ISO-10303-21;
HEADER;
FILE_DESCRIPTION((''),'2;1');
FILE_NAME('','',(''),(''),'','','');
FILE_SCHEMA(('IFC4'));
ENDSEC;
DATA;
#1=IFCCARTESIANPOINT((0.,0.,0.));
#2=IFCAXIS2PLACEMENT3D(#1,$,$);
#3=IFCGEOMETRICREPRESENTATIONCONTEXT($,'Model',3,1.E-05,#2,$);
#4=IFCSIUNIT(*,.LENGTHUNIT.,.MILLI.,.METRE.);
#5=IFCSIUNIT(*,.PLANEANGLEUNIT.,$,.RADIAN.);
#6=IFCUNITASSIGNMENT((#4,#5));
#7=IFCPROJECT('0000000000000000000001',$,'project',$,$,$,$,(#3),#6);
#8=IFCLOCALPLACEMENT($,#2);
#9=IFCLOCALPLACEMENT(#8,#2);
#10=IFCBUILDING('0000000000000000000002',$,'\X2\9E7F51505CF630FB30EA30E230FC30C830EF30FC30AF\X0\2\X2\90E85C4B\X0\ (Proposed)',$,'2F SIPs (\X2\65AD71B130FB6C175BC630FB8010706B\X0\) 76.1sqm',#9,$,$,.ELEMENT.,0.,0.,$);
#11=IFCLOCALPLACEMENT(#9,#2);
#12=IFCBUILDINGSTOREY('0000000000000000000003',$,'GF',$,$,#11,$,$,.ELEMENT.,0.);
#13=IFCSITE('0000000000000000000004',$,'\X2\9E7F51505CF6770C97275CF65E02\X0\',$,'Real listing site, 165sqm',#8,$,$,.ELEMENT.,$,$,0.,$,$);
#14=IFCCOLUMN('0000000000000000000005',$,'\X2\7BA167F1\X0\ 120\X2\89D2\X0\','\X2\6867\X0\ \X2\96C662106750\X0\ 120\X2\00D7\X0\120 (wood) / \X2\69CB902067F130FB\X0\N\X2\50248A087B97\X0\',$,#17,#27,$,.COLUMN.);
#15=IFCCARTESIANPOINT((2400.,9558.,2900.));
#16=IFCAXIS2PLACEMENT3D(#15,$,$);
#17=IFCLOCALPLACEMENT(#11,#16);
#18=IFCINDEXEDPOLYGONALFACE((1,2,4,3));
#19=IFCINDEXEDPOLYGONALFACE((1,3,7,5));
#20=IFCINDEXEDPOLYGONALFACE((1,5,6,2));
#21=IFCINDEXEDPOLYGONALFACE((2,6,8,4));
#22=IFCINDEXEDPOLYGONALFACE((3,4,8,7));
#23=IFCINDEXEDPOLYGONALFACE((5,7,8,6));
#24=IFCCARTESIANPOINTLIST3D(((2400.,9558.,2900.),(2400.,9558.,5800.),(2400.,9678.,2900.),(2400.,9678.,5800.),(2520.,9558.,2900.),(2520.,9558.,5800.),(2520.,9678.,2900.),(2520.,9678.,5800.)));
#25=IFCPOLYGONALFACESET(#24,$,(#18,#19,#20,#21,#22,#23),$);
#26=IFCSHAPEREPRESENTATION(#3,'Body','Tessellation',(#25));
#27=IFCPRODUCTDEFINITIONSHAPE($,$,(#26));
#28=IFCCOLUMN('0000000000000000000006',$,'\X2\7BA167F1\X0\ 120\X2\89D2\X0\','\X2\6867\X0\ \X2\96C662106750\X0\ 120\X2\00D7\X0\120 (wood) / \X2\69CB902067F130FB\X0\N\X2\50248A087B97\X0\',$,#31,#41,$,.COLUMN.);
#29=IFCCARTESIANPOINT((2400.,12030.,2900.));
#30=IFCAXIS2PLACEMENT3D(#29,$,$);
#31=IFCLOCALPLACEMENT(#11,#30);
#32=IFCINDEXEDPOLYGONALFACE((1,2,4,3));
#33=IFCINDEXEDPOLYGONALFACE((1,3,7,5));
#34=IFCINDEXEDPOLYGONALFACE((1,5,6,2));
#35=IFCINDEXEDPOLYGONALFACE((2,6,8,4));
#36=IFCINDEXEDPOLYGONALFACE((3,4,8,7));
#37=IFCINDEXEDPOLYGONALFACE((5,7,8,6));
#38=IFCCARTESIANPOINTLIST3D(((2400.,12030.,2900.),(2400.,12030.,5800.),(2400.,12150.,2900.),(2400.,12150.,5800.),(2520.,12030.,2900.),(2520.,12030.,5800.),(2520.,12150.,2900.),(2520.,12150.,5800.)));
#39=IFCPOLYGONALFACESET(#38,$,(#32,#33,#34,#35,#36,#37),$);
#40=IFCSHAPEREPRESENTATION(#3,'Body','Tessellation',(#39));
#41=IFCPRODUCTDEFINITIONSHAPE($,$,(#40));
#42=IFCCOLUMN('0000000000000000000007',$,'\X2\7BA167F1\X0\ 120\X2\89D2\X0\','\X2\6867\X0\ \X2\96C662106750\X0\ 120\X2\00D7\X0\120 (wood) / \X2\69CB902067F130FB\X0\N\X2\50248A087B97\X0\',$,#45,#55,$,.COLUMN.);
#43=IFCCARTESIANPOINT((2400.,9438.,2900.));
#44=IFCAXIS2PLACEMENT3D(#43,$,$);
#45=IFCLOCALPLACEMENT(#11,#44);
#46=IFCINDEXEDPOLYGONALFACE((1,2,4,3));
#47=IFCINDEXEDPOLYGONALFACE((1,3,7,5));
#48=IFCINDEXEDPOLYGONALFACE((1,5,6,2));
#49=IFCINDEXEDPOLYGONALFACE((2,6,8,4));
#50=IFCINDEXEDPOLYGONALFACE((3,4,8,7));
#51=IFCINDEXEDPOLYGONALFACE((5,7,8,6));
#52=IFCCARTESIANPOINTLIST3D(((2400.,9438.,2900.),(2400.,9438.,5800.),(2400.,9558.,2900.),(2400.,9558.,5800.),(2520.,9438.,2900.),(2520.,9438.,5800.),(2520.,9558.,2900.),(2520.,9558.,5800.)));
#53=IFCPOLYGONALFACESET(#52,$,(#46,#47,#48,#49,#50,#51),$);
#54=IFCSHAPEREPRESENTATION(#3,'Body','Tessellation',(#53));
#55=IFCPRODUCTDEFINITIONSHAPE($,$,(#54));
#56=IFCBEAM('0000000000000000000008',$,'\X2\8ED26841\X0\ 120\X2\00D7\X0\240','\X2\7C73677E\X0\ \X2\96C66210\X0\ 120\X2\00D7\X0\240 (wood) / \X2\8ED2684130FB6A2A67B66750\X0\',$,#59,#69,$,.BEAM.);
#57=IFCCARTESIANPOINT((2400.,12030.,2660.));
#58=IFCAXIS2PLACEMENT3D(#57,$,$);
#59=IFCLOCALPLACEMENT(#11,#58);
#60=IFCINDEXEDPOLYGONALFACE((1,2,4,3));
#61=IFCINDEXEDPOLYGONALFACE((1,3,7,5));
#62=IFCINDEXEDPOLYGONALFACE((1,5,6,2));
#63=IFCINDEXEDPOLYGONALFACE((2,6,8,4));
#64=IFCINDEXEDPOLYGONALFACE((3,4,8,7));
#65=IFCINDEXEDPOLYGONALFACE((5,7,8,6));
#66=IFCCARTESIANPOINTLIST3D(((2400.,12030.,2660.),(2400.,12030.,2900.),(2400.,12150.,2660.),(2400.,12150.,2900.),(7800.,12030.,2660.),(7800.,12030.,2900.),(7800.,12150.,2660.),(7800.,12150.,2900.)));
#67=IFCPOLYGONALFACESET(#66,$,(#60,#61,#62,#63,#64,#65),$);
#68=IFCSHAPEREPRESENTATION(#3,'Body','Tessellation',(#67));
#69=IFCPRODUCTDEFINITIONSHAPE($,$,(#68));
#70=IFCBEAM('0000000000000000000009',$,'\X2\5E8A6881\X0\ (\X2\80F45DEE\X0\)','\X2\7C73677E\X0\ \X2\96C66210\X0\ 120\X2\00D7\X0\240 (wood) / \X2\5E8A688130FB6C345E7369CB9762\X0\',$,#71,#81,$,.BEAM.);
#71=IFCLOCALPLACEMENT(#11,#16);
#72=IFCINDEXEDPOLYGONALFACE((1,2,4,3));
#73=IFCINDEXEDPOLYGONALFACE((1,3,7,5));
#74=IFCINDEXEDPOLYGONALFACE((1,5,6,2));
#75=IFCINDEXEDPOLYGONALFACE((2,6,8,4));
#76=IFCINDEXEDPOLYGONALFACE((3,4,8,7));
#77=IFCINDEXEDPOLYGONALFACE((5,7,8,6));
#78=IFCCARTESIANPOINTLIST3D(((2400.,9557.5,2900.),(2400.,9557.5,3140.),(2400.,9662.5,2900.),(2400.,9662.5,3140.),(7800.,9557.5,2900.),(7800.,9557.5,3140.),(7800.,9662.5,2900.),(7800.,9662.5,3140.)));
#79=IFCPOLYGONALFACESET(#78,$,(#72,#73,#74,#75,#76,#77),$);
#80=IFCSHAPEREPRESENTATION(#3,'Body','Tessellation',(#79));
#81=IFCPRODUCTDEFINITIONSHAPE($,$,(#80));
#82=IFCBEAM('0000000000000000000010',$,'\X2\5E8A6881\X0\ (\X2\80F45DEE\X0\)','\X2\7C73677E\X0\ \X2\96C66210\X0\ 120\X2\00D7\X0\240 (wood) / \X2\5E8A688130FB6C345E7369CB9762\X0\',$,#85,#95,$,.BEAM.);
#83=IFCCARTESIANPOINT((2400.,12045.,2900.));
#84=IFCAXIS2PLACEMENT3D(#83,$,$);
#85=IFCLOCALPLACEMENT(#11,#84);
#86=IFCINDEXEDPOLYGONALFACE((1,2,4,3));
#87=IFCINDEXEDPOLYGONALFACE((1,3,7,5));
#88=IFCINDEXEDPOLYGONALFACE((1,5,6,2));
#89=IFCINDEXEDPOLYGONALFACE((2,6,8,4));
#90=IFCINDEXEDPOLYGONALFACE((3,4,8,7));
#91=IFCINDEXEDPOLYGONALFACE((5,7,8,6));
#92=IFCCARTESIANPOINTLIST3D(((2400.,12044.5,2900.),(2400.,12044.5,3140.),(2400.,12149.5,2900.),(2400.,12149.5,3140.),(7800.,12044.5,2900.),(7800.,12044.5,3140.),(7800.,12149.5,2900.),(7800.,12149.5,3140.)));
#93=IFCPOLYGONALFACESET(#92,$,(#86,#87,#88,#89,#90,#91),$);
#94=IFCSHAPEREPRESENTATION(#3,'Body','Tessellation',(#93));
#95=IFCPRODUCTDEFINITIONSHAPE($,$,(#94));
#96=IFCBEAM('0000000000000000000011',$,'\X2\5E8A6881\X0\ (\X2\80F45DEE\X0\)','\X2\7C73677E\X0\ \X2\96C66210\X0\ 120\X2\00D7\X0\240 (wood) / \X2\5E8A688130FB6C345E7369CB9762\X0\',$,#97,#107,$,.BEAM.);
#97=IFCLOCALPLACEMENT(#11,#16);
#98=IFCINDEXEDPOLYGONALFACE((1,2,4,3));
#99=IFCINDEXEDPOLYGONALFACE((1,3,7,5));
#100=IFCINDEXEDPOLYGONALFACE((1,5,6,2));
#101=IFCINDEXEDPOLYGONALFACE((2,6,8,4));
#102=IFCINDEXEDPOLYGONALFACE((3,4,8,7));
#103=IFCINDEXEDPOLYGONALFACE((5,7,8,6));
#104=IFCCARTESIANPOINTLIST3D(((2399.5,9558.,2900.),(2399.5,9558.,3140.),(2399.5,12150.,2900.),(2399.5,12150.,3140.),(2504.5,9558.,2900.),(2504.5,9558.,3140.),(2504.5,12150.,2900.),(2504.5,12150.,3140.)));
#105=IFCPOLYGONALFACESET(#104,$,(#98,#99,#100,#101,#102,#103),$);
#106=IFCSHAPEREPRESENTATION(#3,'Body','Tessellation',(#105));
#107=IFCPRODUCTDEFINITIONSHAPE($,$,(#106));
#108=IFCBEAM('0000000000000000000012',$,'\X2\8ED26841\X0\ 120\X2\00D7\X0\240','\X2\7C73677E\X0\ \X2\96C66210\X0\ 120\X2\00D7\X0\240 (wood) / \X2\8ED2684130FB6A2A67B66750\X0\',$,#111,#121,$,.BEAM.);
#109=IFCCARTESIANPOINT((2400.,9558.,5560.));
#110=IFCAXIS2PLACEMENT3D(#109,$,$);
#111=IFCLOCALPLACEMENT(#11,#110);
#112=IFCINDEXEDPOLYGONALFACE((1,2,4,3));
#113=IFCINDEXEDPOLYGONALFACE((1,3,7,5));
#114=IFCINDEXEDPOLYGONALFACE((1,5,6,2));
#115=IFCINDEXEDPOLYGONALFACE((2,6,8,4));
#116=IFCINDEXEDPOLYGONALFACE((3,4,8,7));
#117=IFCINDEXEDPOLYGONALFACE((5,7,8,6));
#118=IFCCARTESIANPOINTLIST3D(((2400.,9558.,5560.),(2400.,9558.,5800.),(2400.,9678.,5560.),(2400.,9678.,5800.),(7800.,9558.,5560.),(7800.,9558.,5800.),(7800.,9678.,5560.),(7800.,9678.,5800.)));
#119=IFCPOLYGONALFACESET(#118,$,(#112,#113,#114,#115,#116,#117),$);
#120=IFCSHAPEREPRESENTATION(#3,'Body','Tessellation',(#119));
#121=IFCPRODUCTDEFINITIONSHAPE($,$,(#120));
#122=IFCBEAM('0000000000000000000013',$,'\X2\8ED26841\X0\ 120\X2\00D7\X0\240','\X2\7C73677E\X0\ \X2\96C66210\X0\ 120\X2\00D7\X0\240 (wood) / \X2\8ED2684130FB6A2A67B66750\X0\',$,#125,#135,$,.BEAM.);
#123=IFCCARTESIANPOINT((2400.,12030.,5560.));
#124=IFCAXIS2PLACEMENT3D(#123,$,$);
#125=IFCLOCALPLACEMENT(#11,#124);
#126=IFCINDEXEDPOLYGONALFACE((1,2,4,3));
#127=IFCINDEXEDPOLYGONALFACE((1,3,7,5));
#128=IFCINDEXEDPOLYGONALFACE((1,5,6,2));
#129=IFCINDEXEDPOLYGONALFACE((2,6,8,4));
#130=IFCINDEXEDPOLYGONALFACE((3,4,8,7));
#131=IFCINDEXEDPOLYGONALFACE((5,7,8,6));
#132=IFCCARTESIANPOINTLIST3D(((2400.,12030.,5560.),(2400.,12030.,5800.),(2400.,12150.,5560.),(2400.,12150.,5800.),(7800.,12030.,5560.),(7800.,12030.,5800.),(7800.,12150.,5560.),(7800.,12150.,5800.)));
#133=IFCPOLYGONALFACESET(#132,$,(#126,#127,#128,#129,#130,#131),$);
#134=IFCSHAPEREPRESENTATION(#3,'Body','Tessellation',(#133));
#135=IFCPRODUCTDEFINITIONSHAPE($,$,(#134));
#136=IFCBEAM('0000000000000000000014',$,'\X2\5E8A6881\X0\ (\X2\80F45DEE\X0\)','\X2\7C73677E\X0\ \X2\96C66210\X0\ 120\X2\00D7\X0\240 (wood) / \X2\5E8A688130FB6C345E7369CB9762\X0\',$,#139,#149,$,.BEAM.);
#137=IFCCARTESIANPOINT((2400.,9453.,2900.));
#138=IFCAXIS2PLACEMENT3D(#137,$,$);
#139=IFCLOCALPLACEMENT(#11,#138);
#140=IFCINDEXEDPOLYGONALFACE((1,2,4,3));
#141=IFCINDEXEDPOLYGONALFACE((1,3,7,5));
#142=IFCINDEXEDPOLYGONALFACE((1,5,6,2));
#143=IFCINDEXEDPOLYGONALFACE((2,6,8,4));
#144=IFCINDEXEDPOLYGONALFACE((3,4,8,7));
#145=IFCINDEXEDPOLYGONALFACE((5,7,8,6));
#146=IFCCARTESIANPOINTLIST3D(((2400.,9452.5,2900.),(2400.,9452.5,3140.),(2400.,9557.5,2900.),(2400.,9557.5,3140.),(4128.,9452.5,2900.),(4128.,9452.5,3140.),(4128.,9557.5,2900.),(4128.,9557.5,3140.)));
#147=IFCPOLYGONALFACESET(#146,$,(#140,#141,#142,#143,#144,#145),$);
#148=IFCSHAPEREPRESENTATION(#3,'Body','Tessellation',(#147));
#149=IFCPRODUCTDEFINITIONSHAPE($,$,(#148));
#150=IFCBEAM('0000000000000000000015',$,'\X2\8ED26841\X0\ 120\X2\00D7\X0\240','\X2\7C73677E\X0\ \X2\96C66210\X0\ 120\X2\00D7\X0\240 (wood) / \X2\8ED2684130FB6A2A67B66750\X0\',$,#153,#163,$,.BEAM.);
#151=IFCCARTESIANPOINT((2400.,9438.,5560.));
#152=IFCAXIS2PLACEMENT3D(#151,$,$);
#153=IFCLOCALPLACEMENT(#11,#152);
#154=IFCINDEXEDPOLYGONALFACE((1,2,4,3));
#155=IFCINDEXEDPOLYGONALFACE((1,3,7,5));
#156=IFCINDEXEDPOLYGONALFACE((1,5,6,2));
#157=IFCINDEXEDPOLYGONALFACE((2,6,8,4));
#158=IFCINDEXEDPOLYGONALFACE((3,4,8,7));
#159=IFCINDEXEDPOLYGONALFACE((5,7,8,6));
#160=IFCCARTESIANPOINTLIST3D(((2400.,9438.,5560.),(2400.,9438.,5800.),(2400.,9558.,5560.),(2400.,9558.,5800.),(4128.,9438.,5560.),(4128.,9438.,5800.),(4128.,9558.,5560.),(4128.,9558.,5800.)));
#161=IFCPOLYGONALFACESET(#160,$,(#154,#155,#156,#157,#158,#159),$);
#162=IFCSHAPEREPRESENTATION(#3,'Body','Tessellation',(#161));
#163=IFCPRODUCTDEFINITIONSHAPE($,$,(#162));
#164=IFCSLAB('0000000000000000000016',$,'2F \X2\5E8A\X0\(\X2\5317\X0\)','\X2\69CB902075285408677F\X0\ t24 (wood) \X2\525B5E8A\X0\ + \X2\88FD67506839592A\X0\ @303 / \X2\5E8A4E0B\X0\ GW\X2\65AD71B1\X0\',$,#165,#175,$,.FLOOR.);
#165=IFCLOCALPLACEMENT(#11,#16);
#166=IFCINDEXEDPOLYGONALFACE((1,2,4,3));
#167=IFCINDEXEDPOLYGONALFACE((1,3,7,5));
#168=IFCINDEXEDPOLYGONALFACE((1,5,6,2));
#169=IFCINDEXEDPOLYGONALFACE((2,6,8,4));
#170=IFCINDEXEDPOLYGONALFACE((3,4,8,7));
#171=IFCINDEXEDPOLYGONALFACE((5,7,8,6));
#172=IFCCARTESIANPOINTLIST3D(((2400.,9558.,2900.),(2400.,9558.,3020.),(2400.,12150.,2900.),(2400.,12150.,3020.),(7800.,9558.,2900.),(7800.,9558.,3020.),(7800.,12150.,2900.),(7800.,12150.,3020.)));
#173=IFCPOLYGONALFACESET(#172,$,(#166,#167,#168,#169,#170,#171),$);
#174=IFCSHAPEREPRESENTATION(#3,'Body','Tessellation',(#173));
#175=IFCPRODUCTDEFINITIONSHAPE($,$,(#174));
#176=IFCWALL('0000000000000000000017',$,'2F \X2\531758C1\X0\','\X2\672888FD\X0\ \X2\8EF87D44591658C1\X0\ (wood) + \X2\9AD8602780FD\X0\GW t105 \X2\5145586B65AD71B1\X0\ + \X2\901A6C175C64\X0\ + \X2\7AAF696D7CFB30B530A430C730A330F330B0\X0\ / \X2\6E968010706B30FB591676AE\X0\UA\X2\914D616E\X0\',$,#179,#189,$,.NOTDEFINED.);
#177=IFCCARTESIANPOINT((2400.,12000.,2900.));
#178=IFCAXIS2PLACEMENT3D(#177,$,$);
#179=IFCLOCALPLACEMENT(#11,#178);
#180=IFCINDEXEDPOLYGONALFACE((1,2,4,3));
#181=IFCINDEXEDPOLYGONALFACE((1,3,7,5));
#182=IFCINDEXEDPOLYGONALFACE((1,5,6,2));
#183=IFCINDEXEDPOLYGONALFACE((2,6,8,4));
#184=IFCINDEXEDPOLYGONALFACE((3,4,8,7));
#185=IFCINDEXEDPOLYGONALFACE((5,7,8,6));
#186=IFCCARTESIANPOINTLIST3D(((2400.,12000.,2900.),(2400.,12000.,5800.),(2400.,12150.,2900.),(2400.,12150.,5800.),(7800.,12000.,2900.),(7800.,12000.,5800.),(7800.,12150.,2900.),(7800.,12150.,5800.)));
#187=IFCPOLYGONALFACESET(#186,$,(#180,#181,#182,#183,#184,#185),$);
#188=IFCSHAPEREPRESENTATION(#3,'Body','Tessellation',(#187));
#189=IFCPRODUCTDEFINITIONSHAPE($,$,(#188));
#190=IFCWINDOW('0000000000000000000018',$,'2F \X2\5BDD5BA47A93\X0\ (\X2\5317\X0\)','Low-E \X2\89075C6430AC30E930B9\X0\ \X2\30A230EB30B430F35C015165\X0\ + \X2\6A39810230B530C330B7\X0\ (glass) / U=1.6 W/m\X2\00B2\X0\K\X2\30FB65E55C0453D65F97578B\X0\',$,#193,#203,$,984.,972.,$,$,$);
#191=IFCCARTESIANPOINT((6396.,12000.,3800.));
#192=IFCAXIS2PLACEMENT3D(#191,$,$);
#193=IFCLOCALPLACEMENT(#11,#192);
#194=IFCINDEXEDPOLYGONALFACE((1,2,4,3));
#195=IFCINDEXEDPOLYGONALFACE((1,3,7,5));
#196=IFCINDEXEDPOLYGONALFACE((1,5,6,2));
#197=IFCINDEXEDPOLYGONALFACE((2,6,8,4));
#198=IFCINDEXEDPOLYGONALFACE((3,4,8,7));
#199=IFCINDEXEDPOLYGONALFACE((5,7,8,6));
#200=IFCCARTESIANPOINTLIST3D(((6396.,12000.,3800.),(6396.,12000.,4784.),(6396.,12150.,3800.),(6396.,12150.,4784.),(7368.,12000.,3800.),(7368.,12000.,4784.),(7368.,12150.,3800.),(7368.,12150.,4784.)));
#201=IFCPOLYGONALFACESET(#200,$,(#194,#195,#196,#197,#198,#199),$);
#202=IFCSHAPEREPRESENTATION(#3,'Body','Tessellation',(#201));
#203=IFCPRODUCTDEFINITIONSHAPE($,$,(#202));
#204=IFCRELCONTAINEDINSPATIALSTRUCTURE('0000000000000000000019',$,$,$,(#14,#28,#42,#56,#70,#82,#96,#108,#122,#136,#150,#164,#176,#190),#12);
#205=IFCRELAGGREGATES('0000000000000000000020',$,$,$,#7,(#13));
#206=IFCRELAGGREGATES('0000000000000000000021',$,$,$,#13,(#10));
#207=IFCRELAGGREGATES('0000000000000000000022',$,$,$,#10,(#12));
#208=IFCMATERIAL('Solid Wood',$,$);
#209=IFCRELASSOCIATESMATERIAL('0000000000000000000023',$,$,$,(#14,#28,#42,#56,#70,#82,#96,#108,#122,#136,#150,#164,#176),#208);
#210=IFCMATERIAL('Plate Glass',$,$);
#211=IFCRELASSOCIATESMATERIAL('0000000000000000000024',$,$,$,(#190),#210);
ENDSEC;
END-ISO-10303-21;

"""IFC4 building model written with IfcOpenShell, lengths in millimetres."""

from ifc_helpers import new_model, si_unit, frame, frame_2d, origin, place, context, project, spatial, rectangle, extrude, material, element, fill, save


model = new_model("IFC4")

# Units and contexts
model_context = context("Model", 3, precision=1e-05, world=origin())
ifc_project = project(units=[si_unit("LENGTHUNIT", "METRE", prefix="MILLI"), si_unit("PLANEANGLEUNIT", "RADIAN")], contexts=[model_context])

# Site, building, storey
site_placement = place(None, origin())
site = spatial("IfcSite", under=ifc_project, at=site_placement, Name="鹿児島県霧島市", ObjectType="Real listing site, 165sqm", CompositionType="ELEMENT", RefElevation=0.0)
building_placement = place(site_placement, origin())
building = spatial("IfcBuilding", under=site, at=building_placement, Name="鹿児島・リモートワーク2部屋 (Proposed)", ObjectType="2F SIPs (断熱・気密・耐火) 76.1sqm", CompositionType="ELEMENT", ElevationOfRefHeight=0.0, ElevationOfTerrain=0.0)
storey_placement = place(building_placement, origin())
storey = spatial("IfcBuildingStorey", under=building, at=storey_placement, Name="GF", CompositionType="ELEMENT", Elevation=0.0)

# Columns
ifc_material_1 = material(Name="Solid Wood")
column_1_placement = place(storey_placement, frame((2400.0, 9558.0, 2900.0)))
element("IfcColumn", 1, at=column_1_placement, inside=storey, material=ifc_material_1, Name="管柱 120角", Description="桧 集成材 120×120 (wood) / 構造柱・N値計算", PredefinedType="COLUMN", context=model_context, shape_type="SweptSolid", body=[
    extrude(rectangle(XDim=120.0, YDim=120.0, at=frame_2d((60.0, 60.0))), frame((2400.0, 9558.0, 2900.0)), (0.0, 0.0, 1.0), 2900.0),
])
column_2_placement = place(storey_placement, frame((2400.0, 12030.0, 2900.0)))
element("IfcColumn", 2, at=column_2_placement, inside=storey, material=ifc_material_1, Name="管柱 120角", Description="桧 集成材 120×120 (wood) / 構造柱・N値計算", PredefinedType="COLUMN", context=model_context, shape_type="SweptSolid", body=[
    extrude(rectangle(XDim=120.0, YDim=120.0, at=frame_2d((60.0, 60.0))), frame((2400.0, 12030.0, 2900.0)), (0.0, 0.0, 1.0), 2900.0),
])
column_3_placement = place(storey_placement, frame((2400.0, 9438.0, 2900.0)))
element("IfcColumn", 3, at=column_3_placement, inside=storey, material=ifc_material_1, Name="管柱 120角", Description="桧 集成材 120×120 (wood) / 構造柱・N値計算", PredefinedType="COLUMN", context=model_context, shape_type="SweptSolid", body=[
    extrude(rectangle(XDim=120.0, YDim=120.0, at=frame_2d((60.0, 60.0))), frame((2400.0, 9438.0, 2900.0)), (0.0, 0.0, 1.0), 2900.0),
])

# Beams
beam_1_placement = place(storey_placement, frame((2400.0, 12030.0, 2660.0)))
element("IfcBeam", 4, at=beam_1_placement, inside=storey, material=ifc_material_1, Name="軒桁 120×240", Description="米松 集成 120×240 (wood) / 軒桁・横架材", PredefinedType="BEAM", context=model_context, shape_type="SweptSolid", body=[
    extrude(rectangle(XDim=5400.0, YDim=120.0, at=frame_2d((2700.0, 60.0))), frame((2400.0, 12030.0, 2660.0)), (0.0, 0.0, 1.0), 240.0),
])
beam_2_placement = place(storey_placement, frame((2400.0, 9558.0, 2900.0)))
element("IfcBeam", 5, at=beam_2_placement, inside=storey, material=ifc_material_1, Name="床梁 (胴差)", Description="米松 集成 120×240 (wood) / 床梁・水平構面", PredefinedType="BEAM", context=model_context, shape_type="SweptSolid", body=[
    extrude(rectangle(XDim=5400.0, YDim=105.0, at=frame_2d((2700.0, 52.0))), frame((2400.0, 9558.0, 2900.0)), (0.0, 0.0, 1.0), 240.0),
])
beam_3_placement = place(storey_placement, frame((2400.0, 12045.0, 2900.0)))
element("IfcBeam", 6, at=beam_3_placement, inside=storey, material=ifc_material_1, Name="床梁 (胴差)", Description="米松 集成 120×240 (wood) / 床梁・水平構面", PredefinedType="BEAM", context=model_context, shape_type="SweptSolid", body=[
    extrude(rectangle(XDim=5400.0, YDim=105.0, at=frame_2d((2700.0, 52.0))), frame((2400.0, 12045.0, 2900.0)), (0.0, 0.0, 1.0), 240.0),
])
beam_4_placement = place(storey_placement, frame((2400.0, 9558.0, 2900.0)))
element("IfcBeam", 7, at=beam_4_placement, inside=storey, material=ifc_material_1, Name="床梁 (胴差)", Description="米松 集成 120×240 (wood) / 床梁・水平構面", PredefinedType="BEAM", context=model_context, shape_type="SweptSolid", body=[
    extrude(rectangle(XDim=105.0, YDim=2592.0, at=frame_2d((52.0, 1296.0))), frame((2400.0, 9558.0, 2900.0)), (0.0, 0.0, 1.0), 240.0),
])
beam_5_placement = place(storey_placement, frame((2400.0, 9558.0, 5560.0)))
element("IfcBeam", 8, at=beam_5_placement, inside=storey, material=ifc_material_1, Name="軒桁 120×240", Description="米松 集成 120×240 (wood) / 軒桁・横架材", PredefinedType="BEAM", context=model_context, shape_type="SweptSolid", body=[
    extrude(rectangle(XDim=5400.0, YDim=120.0, at=frame_2d((2700.0, 60.0))), frame((2400.0, 9558.0, 5560.0)), (0.0, 0.0, 1.0), 240.0),
])
beam_6_placement = place(storey_placement, frame((2400.0, 12030.0, 5560.0)))
element("IfcBeam", 9, at=beam_6_placement, inside=storey, material=ifc_material_1, Name="軒桁 120×240", Description="米松 集成 120×240 (wood) / 軒桁・横架材", PredefinedType="BEAM", context=model_context, shape_type="SweptSolid", body=[
    extrude(rectangle(XDim=5400.0, YDim=120.0, at=frame_2d((2700.0, 60.0))), frame((2400.0, 12030.0, 5560.0)), (0.0, 0.0, 1.0), 240.0),
])
beam_7_placement = place(storey_placement, frame((2400.0, 9453.0, 2900.0)))
element("IfcBeam", 10, at=beam_7_placement, inside=storey, material=ifc_material_1, Name="床梁 (胴差)", Description="米松 集成 120×240 (wood) / 床梁・水平構面", PredefinedType="BEAM", context=model_context, shape_type="SweptSolid", body=[
    extrude(rectangle(XDim=1728.0, YDim=105.0, at=frame_2d((864.0, 52.0))), frame((2400.0, 9453.0, 2900.0)), (0.0, 0.0, 1.0), 240.0),
])
beam_8_placement = place(storey_placement, frame((2400.0, 9438.0, 5560.0)))
element("IfcBeam", 11, at=beam_8_placement, inside=storey, material=ifc_material_1, Name="軒桁 120×240", Description="米松 集成 120×240 (wood) / 軒桁・横架材", PredefinedType="BEAM", context=model_context, shape_type="SweptSolid", body=[
    extrude(rectangle(XDim=1728.0, YDim=120.0, at=frame_2d((864.0, 60.0))), frame((2400.0, 9438.0, 5560.0)), (0.0, 0.0, 1.0), 240.0),
])

# Slab
slab_placement = place(storey_placement, frame((2400.0, 9558.0, 2900.0)))
element("IfcSlab", 12, at=slab_placement, inside=storey, material=ifc_material_1, Name="2F 床(北)", Description="構造用合板 t24 (wood) 剛床 + 製材根太 @303 / 床下 GW断熱", PredefinedType="FLOOR", context=model_context, shape_type="SweptSolid", body=[
    extrude(rectangle(XDim=5400.0, YDim=2592.0, at=frame_2d((2700.0, 1296.0))), frame((2400.0, 9558.0, 2900.0)), (0.0, 0.0, 1.0), 120.0),
])

# Wall, opening, window
wall_placement = place(storey_placement, frame((2400.0, 12000.0, 2900.0)))
wall = element("IfcWall", 13, at=wall_placement, inside=storey, material=ifc_material_1, Name="2F 北壁", Description="木製 軸組外壁 (wood) + 高性能GW t105 充填断熱 + 通気層 + 窯業系サイディング / 準耐火・外皮UA配慮", PredefinedType="NOTDEFINED", context=model_context, shape_type="SweptSolid", body=[
    extrude(rectangle(XDim=5400.0, YDim=150.0, at=frame_2d((2700.0, 75.0))), frame((2400.0, 12000.0, 2900.0)), (0.0, 0.0, 1.0), 2900.0),
])
opening_placement = place(storey_placement, frame((6396.0, 12000.0, 3800.0)))
opening = element("IfcOpeningElement", 14, at=opening_placement, cuts=wall, PredefinedType="NOTDEFINED", context=model_context, shape_type="SweptSolid", body=[
    extrude(rectangle(XDim=972.0, YDim=150.0, at=frame_2d((486.0, 75.0))), frame((6396.0, 12000.0, 3800.0)), (0.0, 0.0, 1.0), 984.0),
])
ifc_material_2 = material(Name="Plate Glass")
window_placement = place(storey_placement, frame((6396.0, 12000.0, 3800.0)))
window = element("IfcWindow", 15, at=window_placement, inside=storey, material=ifc_material_2, Name="2F 寝室窓 (北)", Description="Low-E 複層ガラス アルゴン封入 + 樹脂サッシ (glass) / U=1.6 W/m²K・日射取得型", OverallHeight=984.0, OverallWidth=972.0, context=model_context, shape_type="SweptSolid", body=[
    extrude(rectangle(XDim=972.0, YDim=150.0, at=frame_2d((486.0, 75.0))), frame((6396.0, 12000.0, 3800.0)), (0.0, 0.0, 1.0), 984.0),
])
fill(opening, window)

save(model, "model.ifc")
